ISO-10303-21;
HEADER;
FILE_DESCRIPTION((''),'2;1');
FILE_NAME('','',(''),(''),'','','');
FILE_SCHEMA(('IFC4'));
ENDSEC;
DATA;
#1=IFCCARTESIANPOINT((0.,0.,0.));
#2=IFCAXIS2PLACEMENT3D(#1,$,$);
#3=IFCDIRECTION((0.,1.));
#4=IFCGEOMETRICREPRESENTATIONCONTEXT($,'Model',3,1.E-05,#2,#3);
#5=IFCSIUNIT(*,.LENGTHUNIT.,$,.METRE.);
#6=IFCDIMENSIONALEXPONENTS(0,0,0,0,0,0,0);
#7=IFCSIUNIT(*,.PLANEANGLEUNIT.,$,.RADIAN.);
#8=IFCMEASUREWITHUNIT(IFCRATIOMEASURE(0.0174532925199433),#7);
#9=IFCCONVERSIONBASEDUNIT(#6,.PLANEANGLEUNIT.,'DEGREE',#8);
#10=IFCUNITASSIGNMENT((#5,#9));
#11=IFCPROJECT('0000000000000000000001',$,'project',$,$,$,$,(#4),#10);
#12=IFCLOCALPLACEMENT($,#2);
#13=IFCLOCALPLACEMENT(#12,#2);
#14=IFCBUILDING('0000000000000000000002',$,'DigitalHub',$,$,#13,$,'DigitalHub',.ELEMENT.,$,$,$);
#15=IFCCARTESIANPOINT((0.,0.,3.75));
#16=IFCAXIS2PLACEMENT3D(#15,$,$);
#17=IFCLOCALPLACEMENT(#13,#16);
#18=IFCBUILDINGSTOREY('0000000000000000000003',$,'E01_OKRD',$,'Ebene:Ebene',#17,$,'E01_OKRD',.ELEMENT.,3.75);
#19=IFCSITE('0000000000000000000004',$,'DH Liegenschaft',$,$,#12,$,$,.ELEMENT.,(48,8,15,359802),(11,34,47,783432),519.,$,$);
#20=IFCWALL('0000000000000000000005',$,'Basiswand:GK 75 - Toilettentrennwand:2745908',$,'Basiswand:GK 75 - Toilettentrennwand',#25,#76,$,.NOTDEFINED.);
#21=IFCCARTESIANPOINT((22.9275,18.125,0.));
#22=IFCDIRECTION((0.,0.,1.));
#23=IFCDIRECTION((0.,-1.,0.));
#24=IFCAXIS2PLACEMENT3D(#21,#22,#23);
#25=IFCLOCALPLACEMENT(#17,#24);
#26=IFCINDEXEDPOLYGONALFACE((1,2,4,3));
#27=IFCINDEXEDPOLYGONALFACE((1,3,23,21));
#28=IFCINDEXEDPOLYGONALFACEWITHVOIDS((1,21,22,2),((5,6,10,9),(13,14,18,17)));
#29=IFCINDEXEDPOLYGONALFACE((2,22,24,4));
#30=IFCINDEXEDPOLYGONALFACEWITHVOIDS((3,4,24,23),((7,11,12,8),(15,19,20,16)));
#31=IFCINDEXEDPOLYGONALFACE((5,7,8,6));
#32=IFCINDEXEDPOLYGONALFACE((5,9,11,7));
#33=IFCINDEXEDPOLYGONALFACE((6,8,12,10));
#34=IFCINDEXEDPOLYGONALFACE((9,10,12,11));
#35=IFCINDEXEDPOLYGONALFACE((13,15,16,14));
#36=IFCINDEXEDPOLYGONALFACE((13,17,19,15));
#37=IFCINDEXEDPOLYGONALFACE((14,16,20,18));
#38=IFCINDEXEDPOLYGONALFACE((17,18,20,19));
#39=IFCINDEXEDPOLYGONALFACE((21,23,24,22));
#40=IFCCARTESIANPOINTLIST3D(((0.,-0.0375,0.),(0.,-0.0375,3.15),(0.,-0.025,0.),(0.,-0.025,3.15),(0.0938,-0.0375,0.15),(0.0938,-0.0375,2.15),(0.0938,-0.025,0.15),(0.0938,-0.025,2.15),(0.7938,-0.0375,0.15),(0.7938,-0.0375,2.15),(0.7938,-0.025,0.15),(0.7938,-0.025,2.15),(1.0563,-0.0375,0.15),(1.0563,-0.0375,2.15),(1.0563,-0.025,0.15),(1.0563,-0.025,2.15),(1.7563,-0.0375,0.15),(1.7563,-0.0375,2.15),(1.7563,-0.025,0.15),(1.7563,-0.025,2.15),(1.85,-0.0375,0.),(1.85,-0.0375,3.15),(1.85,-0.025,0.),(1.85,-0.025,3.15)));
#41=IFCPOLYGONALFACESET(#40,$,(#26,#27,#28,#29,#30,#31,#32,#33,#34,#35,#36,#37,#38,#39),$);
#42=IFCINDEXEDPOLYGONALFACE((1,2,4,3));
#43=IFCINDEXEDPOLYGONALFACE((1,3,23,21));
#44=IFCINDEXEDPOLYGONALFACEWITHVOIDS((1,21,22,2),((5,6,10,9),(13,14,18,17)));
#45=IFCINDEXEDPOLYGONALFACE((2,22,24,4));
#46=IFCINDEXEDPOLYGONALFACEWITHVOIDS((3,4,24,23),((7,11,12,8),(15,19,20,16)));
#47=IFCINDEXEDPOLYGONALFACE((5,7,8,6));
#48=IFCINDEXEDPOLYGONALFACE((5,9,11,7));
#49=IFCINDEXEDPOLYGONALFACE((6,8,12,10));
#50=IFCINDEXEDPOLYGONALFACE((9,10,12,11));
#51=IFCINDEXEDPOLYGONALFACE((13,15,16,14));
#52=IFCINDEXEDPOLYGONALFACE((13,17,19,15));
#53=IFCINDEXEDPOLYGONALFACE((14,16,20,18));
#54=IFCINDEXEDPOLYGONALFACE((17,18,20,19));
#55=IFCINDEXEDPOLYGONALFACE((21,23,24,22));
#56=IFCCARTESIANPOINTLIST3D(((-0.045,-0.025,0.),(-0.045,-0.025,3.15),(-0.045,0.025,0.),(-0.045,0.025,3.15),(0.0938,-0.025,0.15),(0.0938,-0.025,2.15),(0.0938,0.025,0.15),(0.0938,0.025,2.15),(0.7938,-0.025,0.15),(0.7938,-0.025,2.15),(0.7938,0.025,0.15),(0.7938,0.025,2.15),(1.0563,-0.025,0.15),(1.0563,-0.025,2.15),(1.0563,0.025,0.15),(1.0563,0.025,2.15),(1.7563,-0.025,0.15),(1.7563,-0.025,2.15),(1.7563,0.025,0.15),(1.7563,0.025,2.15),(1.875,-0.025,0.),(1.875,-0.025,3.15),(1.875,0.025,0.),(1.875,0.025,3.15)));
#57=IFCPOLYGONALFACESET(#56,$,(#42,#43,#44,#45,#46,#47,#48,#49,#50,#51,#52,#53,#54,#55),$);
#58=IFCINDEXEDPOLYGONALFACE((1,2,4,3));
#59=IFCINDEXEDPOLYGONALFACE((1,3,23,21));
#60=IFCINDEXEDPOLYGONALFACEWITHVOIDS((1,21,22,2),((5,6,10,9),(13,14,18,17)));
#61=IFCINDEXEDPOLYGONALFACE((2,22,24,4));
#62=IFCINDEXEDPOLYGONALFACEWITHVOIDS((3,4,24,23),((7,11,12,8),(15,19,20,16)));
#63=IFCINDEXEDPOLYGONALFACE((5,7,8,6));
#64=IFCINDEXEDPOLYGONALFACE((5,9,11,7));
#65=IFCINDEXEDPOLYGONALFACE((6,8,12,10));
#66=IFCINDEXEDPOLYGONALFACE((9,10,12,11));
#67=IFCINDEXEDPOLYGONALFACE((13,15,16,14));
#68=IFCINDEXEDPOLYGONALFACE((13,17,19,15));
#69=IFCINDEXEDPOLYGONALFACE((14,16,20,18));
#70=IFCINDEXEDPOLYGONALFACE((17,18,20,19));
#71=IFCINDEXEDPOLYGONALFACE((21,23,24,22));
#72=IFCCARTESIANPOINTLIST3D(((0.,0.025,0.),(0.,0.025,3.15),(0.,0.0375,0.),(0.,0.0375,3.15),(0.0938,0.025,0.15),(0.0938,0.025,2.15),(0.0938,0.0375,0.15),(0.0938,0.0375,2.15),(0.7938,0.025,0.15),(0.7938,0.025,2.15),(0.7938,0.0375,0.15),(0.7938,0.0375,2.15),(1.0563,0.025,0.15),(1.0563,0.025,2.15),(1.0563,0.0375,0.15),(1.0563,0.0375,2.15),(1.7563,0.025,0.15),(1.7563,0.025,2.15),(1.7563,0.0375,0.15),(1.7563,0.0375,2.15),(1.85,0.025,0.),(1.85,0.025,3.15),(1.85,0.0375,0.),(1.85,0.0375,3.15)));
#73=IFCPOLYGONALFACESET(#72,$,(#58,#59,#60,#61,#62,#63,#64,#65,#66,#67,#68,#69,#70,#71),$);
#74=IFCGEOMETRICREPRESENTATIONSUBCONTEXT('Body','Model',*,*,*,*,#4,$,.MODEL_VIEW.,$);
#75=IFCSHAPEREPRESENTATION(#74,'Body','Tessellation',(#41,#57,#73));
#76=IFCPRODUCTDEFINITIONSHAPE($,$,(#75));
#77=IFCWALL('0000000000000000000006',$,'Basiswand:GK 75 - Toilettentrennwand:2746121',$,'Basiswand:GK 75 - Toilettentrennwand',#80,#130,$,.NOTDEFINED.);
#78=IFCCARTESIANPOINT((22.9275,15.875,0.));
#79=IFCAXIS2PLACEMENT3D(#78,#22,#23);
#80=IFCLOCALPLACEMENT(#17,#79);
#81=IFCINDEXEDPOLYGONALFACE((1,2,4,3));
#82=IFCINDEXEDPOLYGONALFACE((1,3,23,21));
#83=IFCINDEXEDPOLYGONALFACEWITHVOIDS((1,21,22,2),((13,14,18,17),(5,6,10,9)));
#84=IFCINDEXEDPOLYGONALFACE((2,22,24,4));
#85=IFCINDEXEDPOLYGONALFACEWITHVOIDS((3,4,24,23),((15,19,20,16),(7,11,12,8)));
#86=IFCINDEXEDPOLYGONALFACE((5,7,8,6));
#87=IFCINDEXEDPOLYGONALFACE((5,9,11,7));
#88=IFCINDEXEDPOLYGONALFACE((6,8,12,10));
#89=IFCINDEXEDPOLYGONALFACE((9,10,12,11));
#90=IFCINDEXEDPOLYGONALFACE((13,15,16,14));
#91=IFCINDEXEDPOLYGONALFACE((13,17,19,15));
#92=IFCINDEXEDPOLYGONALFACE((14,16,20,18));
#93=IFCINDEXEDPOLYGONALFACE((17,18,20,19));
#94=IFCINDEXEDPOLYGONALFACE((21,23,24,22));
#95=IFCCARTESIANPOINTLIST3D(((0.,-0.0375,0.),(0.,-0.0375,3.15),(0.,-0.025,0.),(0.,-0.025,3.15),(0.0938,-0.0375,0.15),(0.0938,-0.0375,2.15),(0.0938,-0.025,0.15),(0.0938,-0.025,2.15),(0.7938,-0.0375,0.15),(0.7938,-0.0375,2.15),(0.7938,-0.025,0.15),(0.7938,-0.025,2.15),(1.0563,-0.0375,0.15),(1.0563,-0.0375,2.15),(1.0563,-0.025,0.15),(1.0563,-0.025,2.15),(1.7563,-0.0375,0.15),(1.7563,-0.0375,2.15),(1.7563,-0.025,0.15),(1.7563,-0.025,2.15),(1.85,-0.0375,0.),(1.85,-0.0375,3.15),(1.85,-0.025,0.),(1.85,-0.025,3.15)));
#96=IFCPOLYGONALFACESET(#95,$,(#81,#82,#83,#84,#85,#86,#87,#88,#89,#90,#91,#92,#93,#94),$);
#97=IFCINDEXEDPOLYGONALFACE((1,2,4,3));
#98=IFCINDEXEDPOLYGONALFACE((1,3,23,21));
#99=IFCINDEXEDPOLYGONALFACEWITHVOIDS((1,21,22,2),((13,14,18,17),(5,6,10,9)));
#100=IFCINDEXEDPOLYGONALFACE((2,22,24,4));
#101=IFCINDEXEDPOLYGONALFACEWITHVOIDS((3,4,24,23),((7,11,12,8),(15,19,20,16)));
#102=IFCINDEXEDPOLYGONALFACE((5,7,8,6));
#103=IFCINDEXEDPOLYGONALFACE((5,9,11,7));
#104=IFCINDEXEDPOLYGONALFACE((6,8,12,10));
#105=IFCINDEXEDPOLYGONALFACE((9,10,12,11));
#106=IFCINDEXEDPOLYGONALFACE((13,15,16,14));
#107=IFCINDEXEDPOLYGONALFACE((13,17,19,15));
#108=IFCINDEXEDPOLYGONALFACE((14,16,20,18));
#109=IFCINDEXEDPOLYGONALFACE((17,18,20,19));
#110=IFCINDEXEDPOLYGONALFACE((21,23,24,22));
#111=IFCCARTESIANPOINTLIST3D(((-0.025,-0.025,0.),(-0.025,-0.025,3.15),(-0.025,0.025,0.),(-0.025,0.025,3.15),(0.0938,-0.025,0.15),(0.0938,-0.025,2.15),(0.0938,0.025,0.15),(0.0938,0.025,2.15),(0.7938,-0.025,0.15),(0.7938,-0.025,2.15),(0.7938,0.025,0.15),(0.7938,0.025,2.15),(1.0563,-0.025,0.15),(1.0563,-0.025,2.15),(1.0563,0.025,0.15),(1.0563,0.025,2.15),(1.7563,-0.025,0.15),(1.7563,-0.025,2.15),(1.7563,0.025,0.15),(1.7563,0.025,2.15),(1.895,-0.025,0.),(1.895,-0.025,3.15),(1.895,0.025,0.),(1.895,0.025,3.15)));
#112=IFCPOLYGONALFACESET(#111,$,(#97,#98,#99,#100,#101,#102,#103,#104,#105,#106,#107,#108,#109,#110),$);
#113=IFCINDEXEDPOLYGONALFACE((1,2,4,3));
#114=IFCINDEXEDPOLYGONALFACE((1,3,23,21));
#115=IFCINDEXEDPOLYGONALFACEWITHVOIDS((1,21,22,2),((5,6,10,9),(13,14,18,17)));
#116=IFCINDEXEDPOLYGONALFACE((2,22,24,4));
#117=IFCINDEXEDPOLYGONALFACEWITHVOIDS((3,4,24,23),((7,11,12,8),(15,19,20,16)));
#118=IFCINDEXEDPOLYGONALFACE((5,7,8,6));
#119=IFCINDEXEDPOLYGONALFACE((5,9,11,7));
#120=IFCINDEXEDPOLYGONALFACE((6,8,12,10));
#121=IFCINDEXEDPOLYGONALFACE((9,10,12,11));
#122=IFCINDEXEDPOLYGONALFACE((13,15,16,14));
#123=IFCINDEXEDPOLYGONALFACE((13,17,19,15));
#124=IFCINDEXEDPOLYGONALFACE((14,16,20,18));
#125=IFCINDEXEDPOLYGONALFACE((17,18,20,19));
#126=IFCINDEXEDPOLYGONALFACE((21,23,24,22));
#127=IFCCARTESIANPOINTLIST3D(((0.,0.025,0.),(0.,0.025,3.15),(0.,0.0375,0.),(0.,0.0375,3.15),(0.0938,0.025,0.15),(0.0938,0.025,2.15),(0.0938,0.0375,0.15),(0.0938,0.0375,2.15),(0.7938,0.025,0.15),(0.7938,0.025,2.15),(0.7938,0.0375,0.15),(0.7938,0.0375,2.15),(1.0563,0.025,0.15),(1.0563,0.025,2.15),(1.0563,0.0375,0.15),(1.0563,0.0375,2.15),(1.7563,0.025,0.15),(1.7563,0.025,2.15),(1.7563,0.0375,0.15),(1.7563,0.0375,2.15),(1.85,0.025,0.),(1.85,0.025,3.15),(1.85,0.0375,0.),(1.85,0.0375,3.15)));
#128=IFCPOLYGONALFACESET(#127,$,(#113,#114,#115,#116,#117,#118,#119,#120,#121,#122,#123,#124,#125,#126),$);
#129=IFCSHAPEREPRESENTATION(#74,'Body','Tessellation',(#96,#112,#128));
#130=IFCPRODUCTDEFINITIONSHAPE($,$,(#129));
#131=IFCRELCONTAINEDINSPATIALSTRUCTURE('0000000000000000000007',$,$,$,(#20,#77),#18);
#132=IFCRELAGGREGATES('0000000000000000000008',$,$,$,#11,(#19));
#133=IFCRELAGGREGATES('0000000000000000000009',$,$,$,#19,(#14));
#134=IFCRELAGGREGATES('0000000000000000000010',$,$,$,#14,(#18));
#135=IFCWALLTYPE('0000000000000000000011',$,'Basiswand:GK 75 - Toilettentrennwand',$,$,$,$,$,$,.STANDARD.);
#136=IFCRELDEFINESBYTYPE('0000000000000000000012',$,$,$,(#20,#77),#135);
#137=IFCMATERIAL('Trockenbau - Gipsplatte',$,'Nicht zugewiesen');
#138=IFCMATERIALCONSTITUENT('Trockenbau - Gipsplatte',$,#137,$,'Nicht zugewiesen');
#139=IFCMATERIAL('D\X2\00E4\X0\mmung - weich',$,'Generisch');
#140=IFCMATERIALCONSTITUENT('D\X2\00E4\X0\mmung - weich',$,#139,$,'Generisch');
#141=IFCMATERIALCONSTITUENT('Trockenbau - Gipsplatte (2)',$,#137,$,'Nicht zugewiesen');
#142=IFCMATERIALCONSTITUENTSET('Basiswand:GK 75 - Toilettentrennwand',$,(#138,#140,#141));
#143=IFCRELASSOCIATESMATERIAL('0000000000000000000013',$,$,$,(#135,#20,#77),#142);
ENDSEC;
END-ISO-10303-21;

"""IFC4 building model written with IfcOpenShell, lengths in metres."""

from ifc_helpers import new_model, entity, si_unit, converted_unit, direction, frame, origin, place, context, subcontext, project, spatial, indexed_curve, outline, extrude, material, constituent, constituent_set, type_object, element, save


model = new_model("IFC4")

# Units and contexts
model_context = context("Model", 3, precision=1e-05, world=origin(), true_north=direction((0.0, 1.0)))
body_context = subcontext(model_context, "Body", "Model", "MODEL_VIEW")
ifc_project = project(units=[si_unit("LENGTHUNIT", "METRE"), converted_unit("PLANEANGLEUNIT", "DEGREE", entity("IfcRatioMeasure", 0.0174532925199433), si_unit("PLANEANGLEUNIT", "RADIAN"), dimensions=[0, 0, 0, 0, 0, 0, 0])], contexts=[model_context])

# Site, building, storey
site_placement = place(None, frame((0.0, 0.0, 0.0)))
site = spatial("IfcSite", under=ifc_project, at=site_placement, Name="DH Liegenschaft", CompositionType="ELEMENT", RefLatitude=(48, 8, 15, 359802), RefLongitude=(11, 34, 47, 783432), RefElevation=519.0)
building_placement = place(site_placement, origin())
building = spatial("IfcBuilding", under=site, at=building_placement, Name="DigitalHub", LongName="DigitalHub", CompositionType="ELEMENT")
storey_placement = place(building_placement, frame((0.0, 0.0, 3.75)))
storey = spatial("IfcBuildingStorey", under=building, at=storey_placement, Name="E01_OKRD", ObjectType="Ebene:Ebene", LongName="E01_OKRD", CompositionType="ELEMENT", Elevation=3.75)

# Shared definitions
ifc_material_1 = material(Name="Trockenbau - Gipsplatte", Category="Nicht zugewiesen")
ifc_material_2 = material(Name="Dämmung - weich", Category="Generisch")
ifc_constituent_1 = constituent(ifc_material_1, Name="Trockenbau - Gipsplatte", Category="Nicht zugewiesen")
ifc_constituent_2 = constituent(ifc_material_2, Name="Dämmung - weich", Category="Generisch")
ifc_constituent_3 = constituent(ifc_material_1, Name="Trockenbau - Gipsplatte (2)", Category="Nicht zugewiesen")
ifc_constituent_set_1 = constituent_set(constituents=[ifc_constituent_1, ifc_constituent_2, ifc_constituent_3], Name="Basiswand:GK 75 - Toilettentrennwand")
wall_type_1 = type_object("IfcWallType", Name="Basiswand:GK 75 - Toilettentrennwand", PredefinedType="STANDARD", material=ifc_constituent_set_1)

# Walls, openings
wall_1_placement = place(storey_placement, frame((22.9275, 18.125, 0.0), z_axis=(0.0, 0.0, 1.0), x_axis=(0.0, -1.0, 0.0)))
wall_1 = element("IfcWall", 1, at=wall_1_placement, inside=storey, type_object=wall_type_1, material=ifc_constituent_set_1, Name="Basiswand:GK 75 - Toilettentrennwand:2745908", ObjectType="Basiswand:GK 75 - Toilettentrennwand", PredefinedType="NOTDEFINED", context=body_context, shape_type="SweptSolid", body=[
    extrude(outline(indexed_curve([(-1.575, -0.925), (1.575, -0.925), (1.575, -0.0375), (1.575, 0.0375), (1.575, 0.925), (-1.575, 0.925), (-1.575, 0.0375), (-1.575, -0.0375), (-1.575, -0.925)], self_intersect=False), holes=[indexed_curve([(0.575, 0.1312), (-1.425, 0.1312), (-1.425, 0.8312), (0.575, 0.8312), (0.575, 0.1312)], self_intersect=False), indexed_curve([(0.575, -0.8313), (-1.425, -0.8313), (-1.425, -0.1313), (0.575, -0.1313), (0.575, -0.8313)], self_intersect=False)]), frame((0.925, -0.0375, 1.575), z_axis=(0.0, 1.0, 0.0), x_axis=(0.0, 0.0, 1.0)), (0.0, 0.0, 1.0), 0.0125),
    extrude(outline(indexed_curve([(-1.575, -0.96), (1.575, -0.96), (1.575, 0.96), (-1.575, 0.96), (-1.575, -0.96)], self_intersect=False), holes=[indexed_curve([(0.575, -0.8213), (-1.425, -0.8213), (-1.425, -0.1213), (0.575, -0.1213), (0.575, -0.8213)], self_intersect=False), indexed_curve([(0.575, 0.1412), (-1.425, 0.1412), (-1.425, 0.8412), (0.575, 0.8412), (0.575, 0.1412)], self_intersect=False)]), frame((0.915, -0.025, 1.575), z_axis=(0.0, 1.0, 0.0), x_axis=(0.0, 0.0, 1.0)), (0.0, 0.0, 1.0), 0.05),
    extrude(outline(indexed_curve([(-1.575, -0.925), (1.575, -0.925), (1.575, 0.925), (-1.575, 0.925), (-1.575, -0.925)], self_intersect=False), holes=[indexed_curve([(0.575, -0.8313), (-1.425, -0.8313), (-1.425, -0.1313), (0.575, -0.1313), (0.575, -0.8313)], self_intersect=False), indexed_curve([(0.575, 0.1312), (-1.425, 0.1312), (-1.425, 0.8312), (0.575, 0.8312), (0.575, 0.1312)], self_intersect=False)]), frame((0.925, 0.025, 1.575), z_axis=(0.0, 1.0, 0.0), x_axis=(0.0, 0.0, 1.0)), (0.0, 0.0, 1.0), 0.0125),
])
opening_1_placement = place(wall_1_placement, frame((1.7563, -0.0375, 0.15)))
element("IfcOpeningElement", 2, at=opening_1_placement, cuts=wall_1, PredefinedType="OPENING", context=body_context, shape_type="SweptSolid", body=[
    extrude(outline(indexed_curve([(-1.0, -0.35), (1.0, -0.35), (1.0, 0.35), (-1.0, 0.35), (-1.0, -0.35)], self_intersect=False)), frame((-0.35, 0.0, 1.0), z_axis=(0.0, 1.0, 0.0), x_axis=(0.0, 0.0, -1.0)), (0.0, 0.0, 1.0), 0.075),
])
opening_2_placement = place(wall_1_placement, frame((0.7937, -0.0375, 0.15)))
element("IfcOpeningElement", 3, at=opening_2_placement, cuts=wall_1, PredefinedType="OPENING", context=body_context, shape_type="SweptSolid", body=[
    extrude(outline(indexed_curve([(-1.0, -0.35), (1.0, -0.35), (1.0, 0.35), (-1.0, 0.35), (-1.0, -0.35)], self_intersect=False)), frame((-0.35, 0.0, 1.0), z_axis=(0.0, 1.0, 0.0), x_axis=(0.0, 0.0, -1.0)), (0.0, 0.0, 1.0), 0.075),
])
wall_2_placement = place(storey_placement, frame((22.9275, 15.875, 0.0), z_axis=(0.0, 0.0, 1.0), x_axis=(0.0, -1.0, 0.0)))
wall_2 = element("IfcWall", 4, at=wall_2_placement, inside=storey, type_object=wall_type_1, material=ifc_constituent_set_1, Name="Basiswand:GK 75 - Toilettentrennwand:2746121", ObjectType="Basiswand:GK 75 - Toilettentrennwand", PredefinedType="NOTDEFINED", context=body_context, shape_type="SweptSolid", body=[
    extrude(outline(indexed_curve([(-1.575, -0.925), (1.575, -0.925), (1.575, -0.0375), (1.575, 0.0375), (1.575, 0.925), (-1.575, 0.925), (-1.575, 0.0375), (-1.575, -0.0375), (-1.575, -0.925)], self_intersect=False), holes=[indexed_curve([(0.575, -0.8312), (-1.425, -0.8312), (-1.425, -0.1312), (0.575, -0.1312), (0.575, -0.8312)], self_intersect=False), indexed_curve([(0.575, 0.1312), (-1.425, 0.1312), (-1.425, 0.8312), (0.575, 0.8312), (0.575, 0.1312)], self_intersect=False)]), frame((0.925, -0.0375, 1.575), z_axis=(0.0, 1.0, 0.0), x_axis=(0.0, 0.0, 1.0)), (0.0, 0.0, 1.0), 0.0125),
    extrude(outline(indexed_curve([(-1.575, -0.96), (1.575, -0.96), (1.575, 0.96), (-1.575, 0.96), (-1.575, -0.96)], self_intersect=False), holes=[indexed_curve([(0.575, 0.1212), (-1.425, 0.1212), (-1.425, 0.8212), (0.575, 0.8212), (0.575, 0.1212)], self_intersect=False), indexed_curve([(0.575, -0.8412), (-1.425, -0.8412), (-1.425, -0.1412), (0.575, -0.1412), (0.575, -0.8412)], self_intersect=False)]), frame((0.935, -0.025, 1.575), z_axis=(0.0, 1.0, 0.0), x_axis=(0.0, 0.0, 1.0)), (0.0, 0.0, 1.0), 0.05),
    extrude(outline(indexed_curve([(-1.575, -0.925), (1.575, -0.925), (1.575, 0.925), (-1.575, 0.925), (-1.575, -0.925)], self_intersect=False), holes=[indexed_curve([(0.575, 0.1312), (-1.425, 0.1312), (-1.425, 0.8312), (0.575, 0.8312), (0.575, 0.1312)], self_intersect=False), indexed_curve([(0.575, -0.8312), (-1.425, -0.8312), (-1.425, -0.1312), (0.575, -0.1312), (0.575, -0.8312)], self_intersect=False)]), frame((0.925, 0.025, 1.575), z_axis=(0.0, 1.0, 0.0), x_axis=(0.0, 0.0, 1.0)), (0.0, 0.0, 1.0), 0.0125),
])
opening_3_placement = place(wall_2_placement, frame((0.7938, -0.0375, 0.15)))
element("IfcOpeningElement", 5, at=opening_3_placement, cuts=wall_2, PredefinedType="OPENING", context=body_context, shape_type="SweptSolid", body=[
    extrude(outline(indexed_curve([(-1.0, -0.35), (1.0, -0.35), (1.0, 0.35), (-1.0, 0.35), (-1.0, -0.35)], self_intersect=False)), frame((-0.35, 0.0, 1.0), z_axis=(0.0, 1.0, 0.0), x_axis=(0.0, 0.0, -1.0)), (0.0, 0.0, 1.0), 0.075),
])
opening_4_placement = place(wall_2_placement, frame((1.7562, -0.0375, 0.15)))
element("IfcOpeningElement", 6, at=opening_4_placement, cuts=wall_2, PredefinedType="OPENING", context=body_context, shape_type="SweptSolid", body=[
    extrude(outline(indexed_curve([(-1.0, -0.35), (1.0, -0.35), (1.0, 0.35), (-1.0, 0.35), (-1.0, -0.35)], self_intersect=False)), frame((-0.35, 0.0, 1.0), z_axis=(0.0, 1.0, 0.0), x_axis=(0.0, 0.0, -1.0)), (0.0, 0.0, 1.0), 0.075),
])

save(model, "model.ifc")
